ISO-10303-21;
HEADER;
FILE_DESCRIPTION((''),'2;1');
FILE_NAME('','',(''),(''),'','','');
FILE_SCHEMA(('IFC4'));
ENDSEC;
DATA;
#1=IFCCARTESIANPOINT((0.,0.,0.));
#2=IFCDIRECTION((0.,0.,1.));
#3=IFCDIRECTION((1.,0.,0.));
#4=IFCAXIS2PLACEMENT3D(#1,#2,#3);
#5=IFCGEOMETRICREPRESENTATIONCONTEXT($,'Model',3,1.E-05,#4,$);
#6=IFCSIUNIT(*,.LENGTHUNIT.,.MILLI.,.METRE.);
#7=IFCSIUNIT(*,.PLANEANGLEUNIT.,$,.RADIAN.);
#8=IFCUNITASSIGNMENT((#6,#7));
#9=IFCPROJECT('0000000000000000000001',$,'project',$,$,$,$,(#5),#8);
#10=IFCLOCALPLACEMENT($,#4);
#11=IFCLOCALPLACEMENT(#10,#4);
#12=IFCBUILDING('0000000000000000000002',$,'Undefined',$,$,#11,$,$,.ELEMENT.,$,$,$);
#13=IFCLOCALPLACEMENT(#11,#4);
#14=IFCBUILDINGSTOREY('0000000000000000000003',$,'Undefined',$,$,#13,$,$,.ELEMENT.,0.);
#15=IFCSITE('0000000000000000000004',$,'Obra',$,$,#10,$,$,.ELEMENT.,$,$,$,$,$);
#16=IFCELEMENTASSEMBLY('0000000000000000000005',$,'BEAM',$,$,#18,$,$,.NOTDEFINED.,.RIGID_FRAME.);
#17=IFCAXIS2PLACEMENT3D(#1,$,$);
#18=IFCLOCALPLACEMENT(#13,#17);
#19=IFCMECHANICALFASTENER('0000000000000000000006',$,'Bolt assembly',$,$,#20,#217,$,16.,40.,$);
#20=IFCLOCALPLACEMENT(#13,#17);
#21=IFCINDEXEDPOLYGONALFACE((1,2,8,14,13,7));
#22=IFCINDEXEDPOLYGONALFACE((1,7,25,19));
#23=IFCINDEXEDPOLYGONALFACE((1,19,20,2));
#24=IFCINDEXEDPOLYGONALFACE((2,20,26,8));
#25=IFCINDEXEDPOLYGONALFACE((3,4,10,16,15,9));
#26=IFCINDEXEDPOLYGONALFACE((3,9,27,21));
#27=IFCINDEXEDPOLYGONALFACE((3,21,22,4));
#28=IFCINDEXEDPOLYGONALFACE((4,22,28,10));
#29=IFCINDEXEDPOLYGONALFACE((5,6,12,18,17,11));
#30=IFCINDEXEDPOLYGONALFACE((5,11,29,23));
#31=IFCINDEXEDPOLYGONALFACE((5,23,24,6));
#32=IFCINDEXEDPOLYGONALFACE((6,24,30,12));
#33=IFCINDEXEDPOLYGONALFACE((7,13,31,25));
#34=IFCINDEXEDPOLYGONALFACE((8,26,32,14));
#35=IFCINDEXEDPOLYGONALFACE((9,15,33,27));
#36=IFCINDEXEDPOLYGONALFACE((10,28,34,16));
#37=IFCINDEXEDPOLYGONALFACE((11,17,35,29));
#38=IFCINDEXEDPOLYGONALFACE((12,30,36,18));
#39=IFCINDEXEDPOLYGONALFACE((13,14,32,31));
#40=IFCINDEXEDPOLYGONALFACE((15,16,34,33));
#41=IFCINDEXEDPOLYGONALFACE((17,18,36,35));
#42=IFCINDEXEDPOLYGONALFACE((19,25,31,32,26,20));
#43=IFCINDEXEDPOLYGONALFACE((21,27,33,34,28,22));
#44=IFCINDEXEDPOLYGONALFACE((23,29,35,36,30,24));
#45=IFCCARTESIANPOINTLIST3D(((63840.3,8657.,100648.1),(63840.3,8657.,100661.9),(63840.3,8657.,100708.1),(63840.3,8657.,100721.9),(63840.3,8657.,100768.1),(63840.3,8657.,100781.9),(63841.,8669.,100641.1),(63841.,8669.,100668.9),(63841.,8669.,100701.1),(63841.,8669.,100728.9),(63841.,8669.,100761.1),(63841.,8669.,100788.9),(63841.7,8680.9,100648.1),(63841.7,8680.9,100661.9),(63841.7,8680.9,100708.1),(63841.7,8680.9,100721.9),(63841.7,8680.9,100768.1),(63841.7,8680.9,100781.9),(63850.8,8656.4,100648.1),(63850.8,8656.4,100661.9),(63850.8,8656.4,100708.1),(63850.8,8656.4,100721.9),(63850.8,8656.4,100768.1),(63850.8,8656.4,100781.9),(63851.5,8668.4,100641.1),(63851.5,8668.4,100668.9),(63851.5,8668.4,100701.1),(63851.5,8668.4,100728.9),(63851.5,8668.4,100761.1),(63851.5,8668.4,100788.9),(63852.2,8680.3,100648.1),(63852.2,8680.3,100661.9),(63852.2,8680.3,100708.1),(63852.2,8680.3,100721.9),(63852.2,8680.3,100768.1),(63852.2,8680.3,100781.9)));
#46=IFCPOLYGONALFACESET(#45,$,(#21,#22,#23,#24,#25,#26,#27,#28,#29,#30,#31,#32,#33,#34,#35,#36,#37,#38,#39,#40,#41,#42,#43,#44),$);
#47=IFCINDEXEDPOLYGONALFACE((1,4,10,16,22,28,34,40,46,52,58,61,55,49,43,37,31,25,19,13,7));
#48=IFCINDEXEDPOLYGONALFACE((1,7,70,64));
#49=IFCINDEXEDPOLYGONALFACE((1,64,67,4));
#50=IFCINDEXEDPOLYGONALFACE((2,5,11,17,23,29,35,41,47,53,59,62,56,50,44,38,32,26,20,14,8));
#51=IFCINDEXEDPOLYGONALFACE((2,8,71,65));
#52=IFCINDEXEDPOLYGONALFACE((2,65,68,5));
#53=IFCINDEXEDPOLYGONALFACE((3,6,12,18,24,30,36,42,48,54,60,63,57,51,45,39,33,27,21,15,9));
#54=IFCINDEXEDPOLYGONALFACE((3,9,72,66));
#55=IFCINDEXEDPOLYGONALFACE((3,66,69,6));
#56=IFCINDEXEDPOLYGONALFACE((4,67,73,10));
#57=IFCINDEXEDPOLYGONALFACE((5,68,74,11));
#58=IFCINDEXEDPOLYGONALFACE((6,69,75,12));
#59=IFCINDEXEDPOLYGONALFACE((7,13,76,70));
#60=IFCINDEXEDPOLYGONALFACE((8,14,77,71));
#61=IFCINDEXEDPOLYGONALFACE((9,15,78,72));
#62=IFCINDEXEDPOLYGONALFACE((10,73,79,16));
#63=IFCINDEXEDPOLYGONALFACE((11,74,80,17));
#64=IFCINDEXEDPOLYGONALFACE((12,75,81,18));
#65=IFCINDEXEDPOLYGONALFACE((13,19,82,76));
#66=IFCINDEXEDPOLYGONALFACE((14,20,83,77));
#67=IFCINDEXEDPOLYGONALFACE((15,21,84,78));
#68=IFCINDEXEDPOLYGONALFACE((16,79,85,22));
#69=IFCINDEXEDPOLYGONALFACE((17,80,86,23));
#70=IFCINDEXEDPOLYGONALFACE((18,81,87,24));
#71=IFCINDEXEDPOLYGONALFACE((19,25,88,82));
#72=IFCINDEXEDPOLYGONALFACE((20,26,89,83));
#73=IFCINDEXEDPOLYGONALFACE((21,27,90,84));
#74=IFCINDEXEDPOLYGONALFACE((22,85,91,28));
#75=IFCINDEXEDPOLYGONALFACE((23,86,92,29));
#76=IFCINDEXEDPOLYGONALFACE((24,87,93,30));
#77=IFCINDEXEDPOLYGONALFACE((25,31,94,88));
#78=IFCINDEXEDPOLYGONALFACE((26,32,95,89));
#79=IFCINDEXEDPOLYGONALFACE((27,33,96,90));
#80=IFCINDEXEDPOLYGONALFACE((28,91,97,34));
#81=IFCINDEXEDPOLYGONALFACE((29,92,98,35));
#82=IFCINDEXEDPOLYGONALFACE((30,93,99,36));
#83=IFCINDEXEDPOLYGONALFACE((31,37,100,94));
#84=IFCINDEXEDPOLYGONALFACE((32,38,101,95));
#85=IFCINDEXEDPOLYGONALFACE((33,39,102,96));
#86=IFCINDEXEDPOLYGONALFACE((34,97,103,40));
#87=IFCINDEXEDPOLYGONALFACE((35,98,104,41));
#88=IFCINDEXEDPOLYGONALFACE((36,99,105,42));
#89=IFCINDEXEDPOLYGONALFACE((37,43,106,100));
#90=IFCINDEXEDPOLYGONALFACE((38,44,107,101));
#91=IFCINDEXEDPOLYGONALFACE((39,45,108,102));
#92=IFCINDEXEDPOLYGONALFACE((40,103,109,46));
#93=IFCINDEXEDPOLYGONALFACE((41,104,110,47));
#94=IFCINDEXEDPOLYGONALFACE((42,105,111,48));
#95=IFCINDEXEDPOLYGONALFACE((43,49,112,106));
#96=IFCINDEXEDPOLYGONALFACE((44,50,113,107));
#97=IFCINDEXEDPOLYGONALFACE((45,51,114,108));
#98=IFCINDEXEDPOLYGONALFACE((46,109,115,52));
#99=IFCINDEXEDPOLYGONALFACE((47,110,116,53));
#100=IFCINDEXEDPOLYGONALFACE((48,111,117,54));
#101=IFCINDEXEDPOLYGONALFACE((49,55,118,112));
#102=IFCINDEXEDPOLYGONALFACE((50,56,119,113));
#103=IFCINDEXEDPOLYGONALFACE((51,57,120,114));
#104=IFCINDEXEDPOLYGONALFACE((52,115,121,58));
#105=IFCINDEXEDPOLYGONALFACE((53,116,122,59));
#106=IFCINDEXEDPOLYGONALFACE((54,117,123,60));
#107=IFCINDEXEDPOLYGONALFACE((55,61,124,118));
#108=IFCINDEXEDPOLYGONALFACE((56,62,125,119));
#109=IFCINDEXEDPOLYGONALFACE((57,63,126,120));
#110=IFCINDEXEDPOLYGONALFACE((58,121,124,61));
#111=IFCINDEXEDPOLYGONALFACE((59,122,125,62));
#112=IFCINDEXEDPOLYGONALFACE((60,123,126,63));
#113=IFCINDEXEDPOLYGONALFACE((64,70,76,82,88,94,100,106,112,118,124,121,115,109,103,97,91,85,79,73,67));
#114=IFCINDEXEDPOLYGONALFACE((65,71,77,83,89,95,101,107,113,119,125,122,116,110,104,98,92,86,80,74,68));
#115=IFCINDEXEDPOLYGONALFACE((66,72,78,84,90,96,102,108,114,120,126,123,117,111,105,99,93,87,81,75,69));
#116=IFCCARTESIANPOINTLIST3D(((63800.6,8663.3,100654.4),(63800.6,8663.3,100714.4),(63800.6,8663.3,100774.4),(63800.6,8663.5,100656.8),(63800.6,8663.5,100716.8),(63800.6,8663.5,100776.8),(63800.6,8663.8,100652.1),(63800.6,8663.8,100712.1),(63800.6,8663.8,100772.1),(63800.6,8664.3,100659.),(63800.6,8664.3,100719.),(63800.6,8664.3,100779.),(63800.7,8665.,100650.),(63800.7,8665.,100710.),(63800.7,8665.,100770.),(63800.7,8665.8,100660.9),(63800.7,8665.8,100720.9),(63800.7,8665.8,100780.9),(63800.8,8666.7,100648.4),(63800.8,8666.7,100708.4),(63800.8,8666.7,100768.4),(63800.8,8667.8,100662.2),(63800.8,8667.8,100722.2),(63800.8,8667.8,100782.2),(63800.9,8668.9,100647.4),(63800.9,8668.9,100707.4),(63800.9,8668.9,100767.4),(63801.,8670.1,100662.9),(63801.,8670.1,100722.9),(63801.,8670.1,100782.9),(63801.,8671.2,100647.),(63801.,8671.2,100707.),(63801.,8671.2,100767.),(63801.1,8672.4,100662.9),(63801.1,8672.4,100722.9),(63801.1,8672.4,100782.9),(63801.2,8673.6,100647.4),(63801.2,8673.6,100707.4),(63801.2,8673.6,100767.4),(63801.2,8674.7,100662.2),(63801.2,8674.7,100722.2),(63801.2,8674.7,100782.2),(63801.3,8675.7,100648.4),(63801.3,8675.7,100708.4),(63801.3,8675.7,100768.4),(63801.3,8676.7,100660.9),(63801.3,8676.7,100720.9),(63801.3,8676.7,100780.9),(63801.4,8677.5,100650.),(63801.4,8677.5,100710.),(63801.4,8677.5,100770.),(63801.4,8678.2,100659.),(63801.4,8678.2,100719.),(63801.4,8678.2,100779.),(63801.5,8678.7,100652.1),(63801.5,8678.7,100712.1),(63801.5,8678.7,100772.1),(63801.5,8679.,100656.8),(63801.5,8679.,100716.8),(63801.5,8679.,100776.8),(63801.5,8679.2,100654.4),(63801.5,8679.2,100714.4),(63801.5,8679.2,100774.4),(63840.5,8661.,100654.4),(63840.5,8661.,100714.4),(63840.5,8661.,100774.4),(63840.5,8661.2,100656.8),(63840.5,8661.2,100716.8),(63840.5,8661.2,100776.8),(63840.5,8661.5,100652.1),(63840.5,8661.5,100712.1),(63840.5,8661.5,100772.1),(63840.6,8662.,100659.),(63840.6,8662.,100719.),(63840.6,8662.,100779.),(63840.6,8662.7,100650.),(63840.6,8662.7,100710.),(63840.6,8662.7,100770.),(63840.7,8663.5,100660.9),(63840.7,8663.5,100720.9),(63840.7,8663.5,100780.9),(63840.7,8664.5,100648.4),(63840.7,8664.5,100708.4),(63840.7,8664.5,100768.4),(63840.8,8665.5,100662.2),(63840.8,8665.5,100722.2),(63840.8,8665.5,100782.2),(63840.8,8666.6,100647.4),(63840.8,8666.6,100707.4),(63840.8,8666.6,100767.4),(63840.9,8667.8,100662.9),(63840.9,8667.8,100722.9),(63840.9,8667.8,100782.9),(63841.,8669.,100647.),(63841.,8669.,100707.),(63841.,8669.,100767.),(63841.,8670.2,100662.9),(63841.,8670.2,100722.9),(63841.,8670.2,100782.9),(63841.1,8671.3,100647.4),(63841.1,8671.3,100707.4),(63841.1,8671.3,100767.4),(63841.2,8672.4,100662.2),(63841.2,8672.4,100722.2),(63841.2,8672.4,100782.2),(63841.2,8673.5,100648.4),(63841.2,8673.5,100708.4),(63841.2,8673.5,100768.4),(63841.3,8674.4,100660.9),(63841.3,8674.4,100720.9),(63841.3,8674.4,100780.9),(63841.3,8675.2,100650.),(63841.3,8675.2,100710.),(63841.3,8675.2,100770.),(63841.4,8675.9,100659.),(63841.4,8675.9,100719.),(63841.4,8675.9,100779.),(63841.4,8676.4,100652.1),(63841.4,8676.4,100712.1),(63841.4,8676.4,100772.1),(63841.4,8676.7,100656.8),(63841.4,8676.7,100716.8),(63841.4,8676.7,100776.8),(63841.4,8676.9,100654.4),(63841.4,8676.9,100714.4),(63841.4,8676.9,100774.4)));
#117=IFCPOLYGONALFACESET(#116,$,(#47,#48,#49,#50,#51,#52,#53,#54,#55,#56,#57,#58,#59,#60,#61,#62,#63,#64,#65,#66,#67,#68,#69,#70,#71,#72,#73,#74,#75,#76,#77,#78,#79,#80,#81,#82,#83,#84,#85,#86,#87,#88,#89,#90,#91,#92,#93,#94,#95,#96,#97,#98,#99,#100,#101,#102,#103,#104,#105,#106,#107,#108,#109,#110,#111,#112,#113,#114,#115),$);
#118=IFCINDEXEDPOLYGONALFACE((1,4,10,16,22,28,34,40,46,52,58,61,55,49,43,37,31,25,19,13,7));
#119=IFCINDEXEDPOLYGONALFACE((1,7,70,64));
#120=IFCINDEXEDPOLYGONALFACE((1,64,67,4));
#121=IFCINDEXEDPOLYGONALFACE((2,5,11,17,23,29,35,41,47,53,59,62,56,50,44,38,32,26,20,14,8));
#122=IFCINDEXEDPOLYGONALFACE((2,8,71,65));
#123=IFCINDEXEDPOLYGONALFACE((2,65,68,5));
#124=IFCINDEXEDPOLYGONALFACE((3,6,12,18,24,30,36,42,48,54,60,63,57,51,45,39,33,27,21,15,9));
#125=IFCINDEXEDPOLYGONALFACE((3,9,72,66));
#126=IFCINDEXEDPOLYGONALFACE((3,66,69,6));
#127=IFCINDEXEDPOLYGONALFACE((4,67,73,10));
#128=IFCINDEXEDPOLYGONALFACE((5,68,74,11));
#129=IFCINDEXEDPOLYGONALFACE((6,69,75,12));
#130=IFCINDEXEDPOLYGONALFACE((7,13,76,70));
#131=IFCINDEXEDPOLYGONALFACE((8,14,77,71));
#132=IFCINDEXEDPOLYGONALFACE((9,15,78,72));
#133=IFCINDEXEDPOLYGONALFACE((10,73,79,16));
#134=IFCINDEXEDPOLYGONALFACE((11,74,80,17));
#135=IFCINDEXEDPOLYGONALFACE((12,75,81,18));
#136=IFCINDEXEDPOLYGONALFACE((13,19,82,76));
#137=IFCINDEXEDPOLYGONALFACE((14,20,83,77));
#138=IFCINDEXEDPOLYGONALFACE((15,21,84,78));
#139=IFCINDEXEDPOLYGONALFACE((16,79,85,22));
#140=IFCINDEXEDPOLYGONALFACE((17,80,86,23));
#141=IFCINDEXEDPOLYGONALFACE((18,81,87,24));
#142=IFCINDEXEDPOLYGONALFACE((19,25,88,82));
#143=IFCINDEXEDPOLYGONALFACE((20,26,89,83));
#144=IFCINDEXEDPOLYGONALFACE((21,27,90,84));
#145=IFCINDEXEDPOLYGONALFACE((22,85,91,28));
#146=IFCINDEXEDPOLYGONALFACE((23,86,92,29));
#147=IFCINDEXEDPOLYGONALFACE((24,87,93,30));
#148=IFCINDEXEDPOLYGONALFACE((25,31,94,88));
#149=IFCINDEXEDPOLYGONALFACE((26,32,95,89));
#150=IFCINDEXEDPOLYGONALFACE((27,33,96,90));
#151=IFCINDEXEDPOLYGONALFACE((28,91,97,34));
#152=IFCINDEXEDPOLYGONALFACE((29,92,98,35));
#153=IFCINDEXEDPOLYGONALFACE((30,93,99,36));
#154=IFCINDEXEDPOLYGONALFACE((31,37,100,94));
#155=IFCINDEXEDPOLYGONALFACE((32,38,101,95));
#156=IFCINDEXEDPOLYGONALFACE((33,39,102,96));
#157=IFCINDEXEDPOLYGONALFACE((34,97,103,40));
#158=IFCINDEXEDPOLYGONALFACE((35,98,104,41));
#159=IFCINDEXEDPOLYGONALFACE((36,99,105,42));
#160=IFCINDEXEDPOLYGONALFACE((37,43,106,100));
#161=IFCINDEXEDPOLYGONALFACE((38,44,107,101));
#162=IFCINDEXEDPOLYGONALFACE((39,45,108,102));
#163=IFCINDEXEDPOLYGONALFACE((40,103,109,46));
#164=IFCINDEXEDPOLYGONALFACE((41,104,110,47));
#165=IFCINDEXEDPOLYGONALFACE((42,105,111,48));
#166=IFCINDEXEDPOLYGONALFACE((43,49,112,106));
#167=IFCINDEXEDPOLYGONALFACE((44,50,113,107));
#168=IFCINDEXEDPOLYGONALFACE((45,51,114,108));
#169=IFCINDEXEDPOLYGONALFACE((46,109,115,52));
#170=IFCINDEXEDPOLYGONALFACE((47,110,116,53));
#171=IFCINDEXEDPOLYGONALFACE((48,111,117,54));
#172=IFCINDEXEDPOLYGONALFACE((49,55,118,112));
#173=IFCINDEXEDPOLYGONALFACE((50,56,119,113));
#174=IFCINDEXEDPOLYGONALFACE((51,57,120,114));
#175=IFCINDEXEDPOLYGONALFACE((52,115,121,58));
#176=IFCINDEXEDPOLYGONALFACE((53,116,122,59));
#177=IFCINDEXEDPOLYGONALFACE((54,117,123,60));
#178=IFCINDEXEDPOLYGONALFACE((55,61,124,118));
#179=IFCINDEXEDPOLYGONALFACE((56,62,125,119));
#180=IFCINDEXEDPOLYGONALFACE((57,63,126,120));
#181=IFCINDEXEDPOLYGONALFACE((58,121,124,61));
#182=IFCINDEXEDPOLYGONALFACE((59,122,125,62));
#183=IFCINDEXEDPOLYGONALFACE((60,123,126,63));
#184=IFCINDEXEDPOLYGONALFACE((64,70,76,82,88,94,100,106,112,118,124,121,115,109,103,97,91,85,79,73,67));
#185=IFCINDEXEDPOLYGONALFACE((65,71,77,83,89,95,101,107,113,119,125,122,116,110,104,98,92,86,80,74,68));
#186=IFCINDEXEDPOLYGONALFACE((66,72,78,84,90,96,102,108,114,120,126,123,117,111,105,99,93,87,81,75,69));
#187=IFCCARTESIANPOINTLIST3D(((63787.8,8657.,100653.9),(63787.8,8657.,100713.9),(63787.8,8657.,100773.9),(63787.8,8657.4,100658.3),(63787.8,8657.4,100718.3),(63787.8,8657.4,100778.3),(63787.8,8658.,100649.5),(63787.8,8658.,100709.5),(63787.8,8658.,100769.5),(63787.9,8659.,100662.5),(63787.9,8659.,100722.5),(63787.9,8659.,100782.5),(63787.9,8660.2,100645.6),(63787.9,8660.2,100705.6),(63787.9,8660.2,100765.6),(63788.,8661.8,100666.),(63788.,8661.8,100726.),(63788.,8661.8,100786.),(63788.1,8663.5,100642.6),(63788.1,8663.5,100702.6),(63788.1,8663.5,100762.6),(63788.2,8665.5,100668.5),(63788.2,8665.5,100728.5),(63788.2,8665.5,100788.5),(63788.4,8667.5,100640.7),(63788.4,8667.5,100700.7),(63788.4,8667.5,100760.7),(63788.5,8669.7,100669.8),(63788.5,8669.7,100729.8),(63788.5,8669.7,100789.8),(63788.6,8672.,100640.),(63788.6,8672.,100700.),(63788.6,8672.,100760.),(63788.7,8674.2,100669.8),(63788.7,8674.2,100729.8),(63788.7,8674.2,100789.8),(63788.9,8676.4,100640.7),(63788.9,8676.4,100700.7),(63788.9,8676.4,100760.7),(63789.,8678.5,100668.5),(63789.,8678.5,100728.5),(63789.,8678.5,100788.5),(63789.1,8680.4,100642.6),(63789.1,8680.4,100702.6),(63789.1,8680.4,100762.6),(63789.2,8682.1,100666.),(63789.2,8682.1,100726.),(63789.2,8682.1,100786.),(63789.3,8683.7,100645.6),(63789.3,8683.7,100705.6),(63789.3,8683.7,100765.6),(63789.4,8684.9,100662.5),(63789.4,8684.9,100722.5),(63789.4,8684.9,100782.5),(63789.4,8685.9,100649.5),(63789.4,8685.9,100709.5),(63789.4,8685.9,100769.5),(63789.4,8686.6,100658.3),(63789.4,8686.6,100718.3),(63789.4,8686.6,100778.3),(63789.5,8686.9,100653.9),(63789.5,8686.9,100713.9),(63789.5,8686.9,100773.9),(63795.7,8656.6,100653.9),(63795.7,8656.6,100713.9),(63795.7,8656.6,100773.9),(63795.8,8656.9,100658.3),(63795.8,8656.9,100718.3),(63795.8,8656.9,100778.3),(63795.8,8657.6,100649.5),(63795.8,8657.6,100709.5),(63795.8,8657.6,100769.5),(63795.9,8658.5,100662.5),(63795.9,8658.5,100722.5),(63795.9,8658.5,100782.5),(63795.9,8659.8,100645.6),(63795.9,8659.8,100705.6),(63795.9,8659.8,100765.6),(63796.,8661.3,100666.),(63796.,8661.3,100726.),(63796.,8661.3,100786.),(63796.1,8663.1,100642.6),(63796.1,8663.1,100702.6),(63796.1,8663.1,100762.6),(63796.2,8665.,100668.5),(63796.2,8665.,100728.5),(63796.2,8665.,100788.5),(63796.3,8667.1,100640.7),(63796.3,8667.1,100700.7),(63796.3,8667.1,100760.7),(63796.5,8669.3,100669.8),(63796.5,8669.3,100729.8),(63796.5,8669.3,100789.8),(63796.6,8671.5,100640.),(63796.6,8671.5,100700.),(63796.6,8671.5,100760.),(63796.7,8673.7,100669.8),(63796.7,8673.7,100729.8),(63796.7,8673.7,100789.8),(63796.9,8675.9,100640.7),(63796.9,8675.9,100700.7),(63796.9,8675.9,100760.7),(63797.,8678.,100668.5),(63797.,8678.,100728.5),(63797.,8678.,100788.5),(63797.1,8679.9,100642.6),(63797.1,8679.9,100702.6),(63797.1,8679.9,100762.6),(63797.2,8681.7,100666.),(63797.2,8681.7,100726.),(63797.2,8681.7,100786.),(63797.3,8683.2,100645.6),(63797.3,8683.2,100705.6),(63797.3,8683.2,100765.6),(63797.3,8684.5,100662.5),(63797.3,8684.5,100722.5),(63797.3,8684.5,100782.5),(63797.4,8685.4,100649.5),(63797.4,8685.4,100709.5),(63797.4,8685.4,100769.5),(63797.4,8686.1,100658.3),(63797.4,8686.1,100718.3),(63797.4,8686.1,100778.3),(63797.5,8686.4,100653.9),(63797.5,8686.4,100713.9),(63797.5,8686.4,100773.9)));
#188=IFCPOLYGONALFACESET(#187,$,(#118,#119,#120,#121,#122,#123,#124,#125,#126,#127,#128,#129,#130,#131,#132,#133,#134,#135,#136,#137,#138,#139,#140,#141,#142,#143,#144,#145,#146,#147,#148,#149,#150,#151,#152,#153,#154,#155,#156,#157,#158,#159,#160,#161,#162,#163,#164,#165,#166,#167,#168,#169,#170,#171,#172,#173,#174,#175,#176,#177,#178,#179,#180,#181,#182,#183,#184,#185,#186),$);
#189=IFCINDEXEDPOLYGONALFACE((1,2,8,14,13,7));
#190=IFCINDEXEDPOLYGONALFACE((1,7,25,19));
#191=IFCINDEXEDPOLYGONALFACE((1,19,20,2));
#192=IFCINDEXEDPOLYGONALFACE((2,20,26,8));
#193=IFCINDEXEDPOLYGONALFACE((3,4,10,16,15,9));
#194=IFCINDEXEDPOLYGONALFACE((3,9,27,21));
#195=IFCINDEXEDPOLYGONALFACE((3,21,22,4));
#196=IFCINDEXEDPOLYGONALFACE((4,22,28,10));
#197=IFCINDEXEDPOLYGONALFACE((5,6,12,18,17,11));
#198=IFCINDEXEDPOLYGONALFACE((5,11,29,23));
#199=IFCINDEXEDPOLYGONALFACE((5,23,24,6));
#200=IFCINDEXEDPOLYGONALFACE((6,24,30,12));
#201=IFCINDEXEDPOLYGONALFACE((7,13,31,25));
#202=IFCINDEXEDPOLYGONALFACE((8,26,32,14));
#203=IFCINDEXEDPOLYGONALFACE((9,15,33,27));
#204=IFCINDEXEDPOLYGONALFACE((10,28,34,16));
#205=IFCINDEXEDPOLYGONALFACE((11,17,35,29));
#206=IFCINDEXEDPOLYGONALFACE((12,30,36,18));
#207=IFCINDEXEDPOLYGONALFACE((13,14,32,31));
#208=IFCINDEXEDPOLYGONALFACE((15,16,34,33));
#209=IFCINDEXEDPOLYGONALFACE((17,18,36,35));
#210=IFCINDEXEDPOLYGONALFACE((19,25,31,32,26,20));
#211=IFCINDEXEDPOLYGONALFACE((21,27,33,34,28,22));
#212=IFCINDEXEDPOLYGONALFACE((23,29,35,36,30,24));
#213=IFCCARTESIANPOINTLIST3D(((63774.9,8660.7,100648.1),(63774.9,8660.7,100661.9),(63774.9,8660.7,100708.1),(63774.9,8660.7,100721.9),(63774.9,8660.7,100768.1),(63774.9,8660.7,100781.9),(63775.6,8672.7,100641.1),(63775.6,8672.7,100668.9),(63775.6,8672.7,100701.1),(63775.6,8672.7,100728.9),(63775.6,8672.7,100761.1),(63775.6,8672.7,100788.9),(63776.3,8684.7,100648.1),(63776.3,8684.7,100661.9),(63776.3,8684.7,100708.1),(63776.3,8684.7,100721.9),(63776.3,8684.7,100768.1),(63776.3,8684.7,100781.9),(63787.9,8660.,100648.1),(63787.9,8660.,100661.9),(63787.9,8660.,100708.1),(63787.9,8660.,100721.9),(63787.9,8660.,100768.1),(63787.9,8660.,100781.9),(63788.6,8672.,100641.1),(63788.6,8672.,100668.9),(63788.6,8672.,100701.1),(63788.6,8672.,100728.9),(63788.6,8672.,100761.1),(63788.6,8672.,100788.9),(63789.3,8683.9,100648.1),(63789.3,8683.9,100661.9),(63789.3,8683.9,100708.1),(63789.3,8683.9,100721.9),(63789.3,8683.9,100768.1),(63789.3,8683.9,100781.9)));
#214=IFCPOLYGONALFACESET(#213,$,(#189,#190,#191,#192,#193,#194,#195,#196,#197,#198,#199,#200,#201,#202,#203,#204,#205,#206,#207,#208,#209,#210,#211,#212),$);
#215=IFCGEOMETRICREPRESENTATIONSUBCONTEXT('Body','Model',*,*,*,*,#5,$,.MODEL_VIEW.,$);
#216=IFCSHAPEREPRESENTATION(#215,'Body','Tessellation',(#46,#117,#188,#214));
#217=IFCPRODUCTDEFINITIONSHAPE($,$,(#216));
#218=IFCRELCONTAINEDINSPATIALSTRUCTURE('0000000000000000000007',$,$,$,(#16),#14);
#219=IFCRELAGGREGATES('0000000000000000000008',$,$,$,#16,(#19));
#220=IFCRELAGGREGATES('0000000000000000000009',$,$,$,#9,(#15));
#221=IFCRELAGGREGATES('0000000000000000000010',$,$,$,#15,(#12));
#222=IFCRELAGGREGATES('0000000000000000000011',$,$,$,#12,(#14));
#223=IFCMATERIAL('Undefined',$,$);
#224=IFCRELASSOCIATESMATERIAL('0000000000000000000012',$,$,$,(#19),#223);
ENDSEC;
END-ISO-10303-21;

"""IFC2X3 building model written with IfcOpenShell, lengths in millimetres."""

from ifc_helpers import new_model, si_unit, frame, origin_with_axes, origin_2d_with_axis, place, context, subcontext, project, spatial, polyline, circle, outline, extrude, source, transform, mapped, material, element, aggregate, save


model = new_model("IFC2X3")

# Units and contexts
model_context = context("Model", 3, precision=1e-05, world=origin_with_axes())
body_context = subcontext(model_context, "Body", "Model", "MODEL_VIEW")
ifc_project = project(units=[si_unit("LENGTHUNIT", "METRE", prefix="MILLI"), si_unit("PLANEANGLEUNIT", "RADIAN")], contexts=[model_context])

# Site, building, storey
site_placement = place(None, origin_with_axes())
site = spatial("IfcSite", under=ifc_project, at=site_placement, Name="Obra", CompositionType="ELEMENT")
building_placement = place(site_placement, origin_with_axes())
building = spatial("IfcBuilding", under=site, at=building_placement, Name="Undefined", CompositionType="ELEMENT")
storey_placement = place(building_placement, origin_with_axes())
storey = spatial("IfcBuildingStorey", under=building, at=storey_placement, Name="Undefined", CompositionType="ELEMENT", Elevation=0.0)

# Shared definitions
ifc_material_1 = material(Name="Undefined")

# Element assembly, mechanical fastener
assembly_1_placement = place(storey_placement, origin_with_axes())
assembly_1 = element("IfcElementAssembly", 1, at=assembly_1_placement, inside=storey, Name="BEAM", AssemblyPlace="NOTDEFINED", PredefinedType="RIGID_FRAME")
shared_shape_1 = source(origin_with_axes(), body_context, "Body", "SweptSolid", [
    extrude(outline(polyline([(13.9, 0.0), (6.9, 12.0), (-6.9, 12.0), (-13.9, 0.0), (-6.9, -12.0), (6.9, -12.0), (13.9, 0.0)])), frame((0.0, -19.7, 0.0), z_axis=(0.0, 1.0, 0.0), x_axis=(1.0, 0.0, 0.0)), (0.0, 0.0, 1.0), 10.6),
    extrude(circle(Radius=8.0, at=origin_2d_with_axis()), frame((0.0, -9.1, 0.0), z_axis=(0.0, 1.0, 0.0), x_axis=(1.0, 0.0, 0.0)), (0.0, 0.0, 1.0), 40.0),
    extrude(circle(Radius=15.0, at=origin_2d_with_axis()), frame((0.0, 35.3, 0.0), z_axis=(0.0, 1.0, 0.0), x_axis=(1.0, 0.0, 0.0)), (0.0, 0.0, 1.0), 8.0),
    extrude(outline(polyline([(13.9, 0.0), (6.9, 12.0), (-6.9, 12.0), (-13.9, 0.0), (-6.9, -12.0), (6.9, -12.0), (13.9, 0.0)])), frame((0.0, 43.3, 0.0), z_axis=(0.0, 1.0, 0.0), x_axis=(1.0, 0.0, 0.0)), (0.0, 0.0, 1.0), 13.0),
])
mechanical_fastener_1_placement = place(assembly_1_placement, frame((63829.0, 8619.6, 100835.0), z_axis=(0.05711, 0.998368, 0.0), x_axis=(0.0, 0.0, -1.0)))
mechanical_fastener_1 = element("IfcMechanicalFastener", 2, at=mechanical_fastener_1_placement, material=ifc_material_1, Name="Bolt assembly", NominalDiameter=16.0, NominalLength=40.0, context=body_context, shape_type="MappedRepresentation", body=[
    mapped(shared_shape_1, transform((60.0, 0.0, 50.0))),
    mapped(shared_shape_1, transform((120.0, 0.0, 50.0))),
    mapped(shared_shape_1, transform((180.0, 0.0, 50.0))),
])
aggregate(assembly_1, [mechanical_fastener_1])

save(model, "model.ifc")
